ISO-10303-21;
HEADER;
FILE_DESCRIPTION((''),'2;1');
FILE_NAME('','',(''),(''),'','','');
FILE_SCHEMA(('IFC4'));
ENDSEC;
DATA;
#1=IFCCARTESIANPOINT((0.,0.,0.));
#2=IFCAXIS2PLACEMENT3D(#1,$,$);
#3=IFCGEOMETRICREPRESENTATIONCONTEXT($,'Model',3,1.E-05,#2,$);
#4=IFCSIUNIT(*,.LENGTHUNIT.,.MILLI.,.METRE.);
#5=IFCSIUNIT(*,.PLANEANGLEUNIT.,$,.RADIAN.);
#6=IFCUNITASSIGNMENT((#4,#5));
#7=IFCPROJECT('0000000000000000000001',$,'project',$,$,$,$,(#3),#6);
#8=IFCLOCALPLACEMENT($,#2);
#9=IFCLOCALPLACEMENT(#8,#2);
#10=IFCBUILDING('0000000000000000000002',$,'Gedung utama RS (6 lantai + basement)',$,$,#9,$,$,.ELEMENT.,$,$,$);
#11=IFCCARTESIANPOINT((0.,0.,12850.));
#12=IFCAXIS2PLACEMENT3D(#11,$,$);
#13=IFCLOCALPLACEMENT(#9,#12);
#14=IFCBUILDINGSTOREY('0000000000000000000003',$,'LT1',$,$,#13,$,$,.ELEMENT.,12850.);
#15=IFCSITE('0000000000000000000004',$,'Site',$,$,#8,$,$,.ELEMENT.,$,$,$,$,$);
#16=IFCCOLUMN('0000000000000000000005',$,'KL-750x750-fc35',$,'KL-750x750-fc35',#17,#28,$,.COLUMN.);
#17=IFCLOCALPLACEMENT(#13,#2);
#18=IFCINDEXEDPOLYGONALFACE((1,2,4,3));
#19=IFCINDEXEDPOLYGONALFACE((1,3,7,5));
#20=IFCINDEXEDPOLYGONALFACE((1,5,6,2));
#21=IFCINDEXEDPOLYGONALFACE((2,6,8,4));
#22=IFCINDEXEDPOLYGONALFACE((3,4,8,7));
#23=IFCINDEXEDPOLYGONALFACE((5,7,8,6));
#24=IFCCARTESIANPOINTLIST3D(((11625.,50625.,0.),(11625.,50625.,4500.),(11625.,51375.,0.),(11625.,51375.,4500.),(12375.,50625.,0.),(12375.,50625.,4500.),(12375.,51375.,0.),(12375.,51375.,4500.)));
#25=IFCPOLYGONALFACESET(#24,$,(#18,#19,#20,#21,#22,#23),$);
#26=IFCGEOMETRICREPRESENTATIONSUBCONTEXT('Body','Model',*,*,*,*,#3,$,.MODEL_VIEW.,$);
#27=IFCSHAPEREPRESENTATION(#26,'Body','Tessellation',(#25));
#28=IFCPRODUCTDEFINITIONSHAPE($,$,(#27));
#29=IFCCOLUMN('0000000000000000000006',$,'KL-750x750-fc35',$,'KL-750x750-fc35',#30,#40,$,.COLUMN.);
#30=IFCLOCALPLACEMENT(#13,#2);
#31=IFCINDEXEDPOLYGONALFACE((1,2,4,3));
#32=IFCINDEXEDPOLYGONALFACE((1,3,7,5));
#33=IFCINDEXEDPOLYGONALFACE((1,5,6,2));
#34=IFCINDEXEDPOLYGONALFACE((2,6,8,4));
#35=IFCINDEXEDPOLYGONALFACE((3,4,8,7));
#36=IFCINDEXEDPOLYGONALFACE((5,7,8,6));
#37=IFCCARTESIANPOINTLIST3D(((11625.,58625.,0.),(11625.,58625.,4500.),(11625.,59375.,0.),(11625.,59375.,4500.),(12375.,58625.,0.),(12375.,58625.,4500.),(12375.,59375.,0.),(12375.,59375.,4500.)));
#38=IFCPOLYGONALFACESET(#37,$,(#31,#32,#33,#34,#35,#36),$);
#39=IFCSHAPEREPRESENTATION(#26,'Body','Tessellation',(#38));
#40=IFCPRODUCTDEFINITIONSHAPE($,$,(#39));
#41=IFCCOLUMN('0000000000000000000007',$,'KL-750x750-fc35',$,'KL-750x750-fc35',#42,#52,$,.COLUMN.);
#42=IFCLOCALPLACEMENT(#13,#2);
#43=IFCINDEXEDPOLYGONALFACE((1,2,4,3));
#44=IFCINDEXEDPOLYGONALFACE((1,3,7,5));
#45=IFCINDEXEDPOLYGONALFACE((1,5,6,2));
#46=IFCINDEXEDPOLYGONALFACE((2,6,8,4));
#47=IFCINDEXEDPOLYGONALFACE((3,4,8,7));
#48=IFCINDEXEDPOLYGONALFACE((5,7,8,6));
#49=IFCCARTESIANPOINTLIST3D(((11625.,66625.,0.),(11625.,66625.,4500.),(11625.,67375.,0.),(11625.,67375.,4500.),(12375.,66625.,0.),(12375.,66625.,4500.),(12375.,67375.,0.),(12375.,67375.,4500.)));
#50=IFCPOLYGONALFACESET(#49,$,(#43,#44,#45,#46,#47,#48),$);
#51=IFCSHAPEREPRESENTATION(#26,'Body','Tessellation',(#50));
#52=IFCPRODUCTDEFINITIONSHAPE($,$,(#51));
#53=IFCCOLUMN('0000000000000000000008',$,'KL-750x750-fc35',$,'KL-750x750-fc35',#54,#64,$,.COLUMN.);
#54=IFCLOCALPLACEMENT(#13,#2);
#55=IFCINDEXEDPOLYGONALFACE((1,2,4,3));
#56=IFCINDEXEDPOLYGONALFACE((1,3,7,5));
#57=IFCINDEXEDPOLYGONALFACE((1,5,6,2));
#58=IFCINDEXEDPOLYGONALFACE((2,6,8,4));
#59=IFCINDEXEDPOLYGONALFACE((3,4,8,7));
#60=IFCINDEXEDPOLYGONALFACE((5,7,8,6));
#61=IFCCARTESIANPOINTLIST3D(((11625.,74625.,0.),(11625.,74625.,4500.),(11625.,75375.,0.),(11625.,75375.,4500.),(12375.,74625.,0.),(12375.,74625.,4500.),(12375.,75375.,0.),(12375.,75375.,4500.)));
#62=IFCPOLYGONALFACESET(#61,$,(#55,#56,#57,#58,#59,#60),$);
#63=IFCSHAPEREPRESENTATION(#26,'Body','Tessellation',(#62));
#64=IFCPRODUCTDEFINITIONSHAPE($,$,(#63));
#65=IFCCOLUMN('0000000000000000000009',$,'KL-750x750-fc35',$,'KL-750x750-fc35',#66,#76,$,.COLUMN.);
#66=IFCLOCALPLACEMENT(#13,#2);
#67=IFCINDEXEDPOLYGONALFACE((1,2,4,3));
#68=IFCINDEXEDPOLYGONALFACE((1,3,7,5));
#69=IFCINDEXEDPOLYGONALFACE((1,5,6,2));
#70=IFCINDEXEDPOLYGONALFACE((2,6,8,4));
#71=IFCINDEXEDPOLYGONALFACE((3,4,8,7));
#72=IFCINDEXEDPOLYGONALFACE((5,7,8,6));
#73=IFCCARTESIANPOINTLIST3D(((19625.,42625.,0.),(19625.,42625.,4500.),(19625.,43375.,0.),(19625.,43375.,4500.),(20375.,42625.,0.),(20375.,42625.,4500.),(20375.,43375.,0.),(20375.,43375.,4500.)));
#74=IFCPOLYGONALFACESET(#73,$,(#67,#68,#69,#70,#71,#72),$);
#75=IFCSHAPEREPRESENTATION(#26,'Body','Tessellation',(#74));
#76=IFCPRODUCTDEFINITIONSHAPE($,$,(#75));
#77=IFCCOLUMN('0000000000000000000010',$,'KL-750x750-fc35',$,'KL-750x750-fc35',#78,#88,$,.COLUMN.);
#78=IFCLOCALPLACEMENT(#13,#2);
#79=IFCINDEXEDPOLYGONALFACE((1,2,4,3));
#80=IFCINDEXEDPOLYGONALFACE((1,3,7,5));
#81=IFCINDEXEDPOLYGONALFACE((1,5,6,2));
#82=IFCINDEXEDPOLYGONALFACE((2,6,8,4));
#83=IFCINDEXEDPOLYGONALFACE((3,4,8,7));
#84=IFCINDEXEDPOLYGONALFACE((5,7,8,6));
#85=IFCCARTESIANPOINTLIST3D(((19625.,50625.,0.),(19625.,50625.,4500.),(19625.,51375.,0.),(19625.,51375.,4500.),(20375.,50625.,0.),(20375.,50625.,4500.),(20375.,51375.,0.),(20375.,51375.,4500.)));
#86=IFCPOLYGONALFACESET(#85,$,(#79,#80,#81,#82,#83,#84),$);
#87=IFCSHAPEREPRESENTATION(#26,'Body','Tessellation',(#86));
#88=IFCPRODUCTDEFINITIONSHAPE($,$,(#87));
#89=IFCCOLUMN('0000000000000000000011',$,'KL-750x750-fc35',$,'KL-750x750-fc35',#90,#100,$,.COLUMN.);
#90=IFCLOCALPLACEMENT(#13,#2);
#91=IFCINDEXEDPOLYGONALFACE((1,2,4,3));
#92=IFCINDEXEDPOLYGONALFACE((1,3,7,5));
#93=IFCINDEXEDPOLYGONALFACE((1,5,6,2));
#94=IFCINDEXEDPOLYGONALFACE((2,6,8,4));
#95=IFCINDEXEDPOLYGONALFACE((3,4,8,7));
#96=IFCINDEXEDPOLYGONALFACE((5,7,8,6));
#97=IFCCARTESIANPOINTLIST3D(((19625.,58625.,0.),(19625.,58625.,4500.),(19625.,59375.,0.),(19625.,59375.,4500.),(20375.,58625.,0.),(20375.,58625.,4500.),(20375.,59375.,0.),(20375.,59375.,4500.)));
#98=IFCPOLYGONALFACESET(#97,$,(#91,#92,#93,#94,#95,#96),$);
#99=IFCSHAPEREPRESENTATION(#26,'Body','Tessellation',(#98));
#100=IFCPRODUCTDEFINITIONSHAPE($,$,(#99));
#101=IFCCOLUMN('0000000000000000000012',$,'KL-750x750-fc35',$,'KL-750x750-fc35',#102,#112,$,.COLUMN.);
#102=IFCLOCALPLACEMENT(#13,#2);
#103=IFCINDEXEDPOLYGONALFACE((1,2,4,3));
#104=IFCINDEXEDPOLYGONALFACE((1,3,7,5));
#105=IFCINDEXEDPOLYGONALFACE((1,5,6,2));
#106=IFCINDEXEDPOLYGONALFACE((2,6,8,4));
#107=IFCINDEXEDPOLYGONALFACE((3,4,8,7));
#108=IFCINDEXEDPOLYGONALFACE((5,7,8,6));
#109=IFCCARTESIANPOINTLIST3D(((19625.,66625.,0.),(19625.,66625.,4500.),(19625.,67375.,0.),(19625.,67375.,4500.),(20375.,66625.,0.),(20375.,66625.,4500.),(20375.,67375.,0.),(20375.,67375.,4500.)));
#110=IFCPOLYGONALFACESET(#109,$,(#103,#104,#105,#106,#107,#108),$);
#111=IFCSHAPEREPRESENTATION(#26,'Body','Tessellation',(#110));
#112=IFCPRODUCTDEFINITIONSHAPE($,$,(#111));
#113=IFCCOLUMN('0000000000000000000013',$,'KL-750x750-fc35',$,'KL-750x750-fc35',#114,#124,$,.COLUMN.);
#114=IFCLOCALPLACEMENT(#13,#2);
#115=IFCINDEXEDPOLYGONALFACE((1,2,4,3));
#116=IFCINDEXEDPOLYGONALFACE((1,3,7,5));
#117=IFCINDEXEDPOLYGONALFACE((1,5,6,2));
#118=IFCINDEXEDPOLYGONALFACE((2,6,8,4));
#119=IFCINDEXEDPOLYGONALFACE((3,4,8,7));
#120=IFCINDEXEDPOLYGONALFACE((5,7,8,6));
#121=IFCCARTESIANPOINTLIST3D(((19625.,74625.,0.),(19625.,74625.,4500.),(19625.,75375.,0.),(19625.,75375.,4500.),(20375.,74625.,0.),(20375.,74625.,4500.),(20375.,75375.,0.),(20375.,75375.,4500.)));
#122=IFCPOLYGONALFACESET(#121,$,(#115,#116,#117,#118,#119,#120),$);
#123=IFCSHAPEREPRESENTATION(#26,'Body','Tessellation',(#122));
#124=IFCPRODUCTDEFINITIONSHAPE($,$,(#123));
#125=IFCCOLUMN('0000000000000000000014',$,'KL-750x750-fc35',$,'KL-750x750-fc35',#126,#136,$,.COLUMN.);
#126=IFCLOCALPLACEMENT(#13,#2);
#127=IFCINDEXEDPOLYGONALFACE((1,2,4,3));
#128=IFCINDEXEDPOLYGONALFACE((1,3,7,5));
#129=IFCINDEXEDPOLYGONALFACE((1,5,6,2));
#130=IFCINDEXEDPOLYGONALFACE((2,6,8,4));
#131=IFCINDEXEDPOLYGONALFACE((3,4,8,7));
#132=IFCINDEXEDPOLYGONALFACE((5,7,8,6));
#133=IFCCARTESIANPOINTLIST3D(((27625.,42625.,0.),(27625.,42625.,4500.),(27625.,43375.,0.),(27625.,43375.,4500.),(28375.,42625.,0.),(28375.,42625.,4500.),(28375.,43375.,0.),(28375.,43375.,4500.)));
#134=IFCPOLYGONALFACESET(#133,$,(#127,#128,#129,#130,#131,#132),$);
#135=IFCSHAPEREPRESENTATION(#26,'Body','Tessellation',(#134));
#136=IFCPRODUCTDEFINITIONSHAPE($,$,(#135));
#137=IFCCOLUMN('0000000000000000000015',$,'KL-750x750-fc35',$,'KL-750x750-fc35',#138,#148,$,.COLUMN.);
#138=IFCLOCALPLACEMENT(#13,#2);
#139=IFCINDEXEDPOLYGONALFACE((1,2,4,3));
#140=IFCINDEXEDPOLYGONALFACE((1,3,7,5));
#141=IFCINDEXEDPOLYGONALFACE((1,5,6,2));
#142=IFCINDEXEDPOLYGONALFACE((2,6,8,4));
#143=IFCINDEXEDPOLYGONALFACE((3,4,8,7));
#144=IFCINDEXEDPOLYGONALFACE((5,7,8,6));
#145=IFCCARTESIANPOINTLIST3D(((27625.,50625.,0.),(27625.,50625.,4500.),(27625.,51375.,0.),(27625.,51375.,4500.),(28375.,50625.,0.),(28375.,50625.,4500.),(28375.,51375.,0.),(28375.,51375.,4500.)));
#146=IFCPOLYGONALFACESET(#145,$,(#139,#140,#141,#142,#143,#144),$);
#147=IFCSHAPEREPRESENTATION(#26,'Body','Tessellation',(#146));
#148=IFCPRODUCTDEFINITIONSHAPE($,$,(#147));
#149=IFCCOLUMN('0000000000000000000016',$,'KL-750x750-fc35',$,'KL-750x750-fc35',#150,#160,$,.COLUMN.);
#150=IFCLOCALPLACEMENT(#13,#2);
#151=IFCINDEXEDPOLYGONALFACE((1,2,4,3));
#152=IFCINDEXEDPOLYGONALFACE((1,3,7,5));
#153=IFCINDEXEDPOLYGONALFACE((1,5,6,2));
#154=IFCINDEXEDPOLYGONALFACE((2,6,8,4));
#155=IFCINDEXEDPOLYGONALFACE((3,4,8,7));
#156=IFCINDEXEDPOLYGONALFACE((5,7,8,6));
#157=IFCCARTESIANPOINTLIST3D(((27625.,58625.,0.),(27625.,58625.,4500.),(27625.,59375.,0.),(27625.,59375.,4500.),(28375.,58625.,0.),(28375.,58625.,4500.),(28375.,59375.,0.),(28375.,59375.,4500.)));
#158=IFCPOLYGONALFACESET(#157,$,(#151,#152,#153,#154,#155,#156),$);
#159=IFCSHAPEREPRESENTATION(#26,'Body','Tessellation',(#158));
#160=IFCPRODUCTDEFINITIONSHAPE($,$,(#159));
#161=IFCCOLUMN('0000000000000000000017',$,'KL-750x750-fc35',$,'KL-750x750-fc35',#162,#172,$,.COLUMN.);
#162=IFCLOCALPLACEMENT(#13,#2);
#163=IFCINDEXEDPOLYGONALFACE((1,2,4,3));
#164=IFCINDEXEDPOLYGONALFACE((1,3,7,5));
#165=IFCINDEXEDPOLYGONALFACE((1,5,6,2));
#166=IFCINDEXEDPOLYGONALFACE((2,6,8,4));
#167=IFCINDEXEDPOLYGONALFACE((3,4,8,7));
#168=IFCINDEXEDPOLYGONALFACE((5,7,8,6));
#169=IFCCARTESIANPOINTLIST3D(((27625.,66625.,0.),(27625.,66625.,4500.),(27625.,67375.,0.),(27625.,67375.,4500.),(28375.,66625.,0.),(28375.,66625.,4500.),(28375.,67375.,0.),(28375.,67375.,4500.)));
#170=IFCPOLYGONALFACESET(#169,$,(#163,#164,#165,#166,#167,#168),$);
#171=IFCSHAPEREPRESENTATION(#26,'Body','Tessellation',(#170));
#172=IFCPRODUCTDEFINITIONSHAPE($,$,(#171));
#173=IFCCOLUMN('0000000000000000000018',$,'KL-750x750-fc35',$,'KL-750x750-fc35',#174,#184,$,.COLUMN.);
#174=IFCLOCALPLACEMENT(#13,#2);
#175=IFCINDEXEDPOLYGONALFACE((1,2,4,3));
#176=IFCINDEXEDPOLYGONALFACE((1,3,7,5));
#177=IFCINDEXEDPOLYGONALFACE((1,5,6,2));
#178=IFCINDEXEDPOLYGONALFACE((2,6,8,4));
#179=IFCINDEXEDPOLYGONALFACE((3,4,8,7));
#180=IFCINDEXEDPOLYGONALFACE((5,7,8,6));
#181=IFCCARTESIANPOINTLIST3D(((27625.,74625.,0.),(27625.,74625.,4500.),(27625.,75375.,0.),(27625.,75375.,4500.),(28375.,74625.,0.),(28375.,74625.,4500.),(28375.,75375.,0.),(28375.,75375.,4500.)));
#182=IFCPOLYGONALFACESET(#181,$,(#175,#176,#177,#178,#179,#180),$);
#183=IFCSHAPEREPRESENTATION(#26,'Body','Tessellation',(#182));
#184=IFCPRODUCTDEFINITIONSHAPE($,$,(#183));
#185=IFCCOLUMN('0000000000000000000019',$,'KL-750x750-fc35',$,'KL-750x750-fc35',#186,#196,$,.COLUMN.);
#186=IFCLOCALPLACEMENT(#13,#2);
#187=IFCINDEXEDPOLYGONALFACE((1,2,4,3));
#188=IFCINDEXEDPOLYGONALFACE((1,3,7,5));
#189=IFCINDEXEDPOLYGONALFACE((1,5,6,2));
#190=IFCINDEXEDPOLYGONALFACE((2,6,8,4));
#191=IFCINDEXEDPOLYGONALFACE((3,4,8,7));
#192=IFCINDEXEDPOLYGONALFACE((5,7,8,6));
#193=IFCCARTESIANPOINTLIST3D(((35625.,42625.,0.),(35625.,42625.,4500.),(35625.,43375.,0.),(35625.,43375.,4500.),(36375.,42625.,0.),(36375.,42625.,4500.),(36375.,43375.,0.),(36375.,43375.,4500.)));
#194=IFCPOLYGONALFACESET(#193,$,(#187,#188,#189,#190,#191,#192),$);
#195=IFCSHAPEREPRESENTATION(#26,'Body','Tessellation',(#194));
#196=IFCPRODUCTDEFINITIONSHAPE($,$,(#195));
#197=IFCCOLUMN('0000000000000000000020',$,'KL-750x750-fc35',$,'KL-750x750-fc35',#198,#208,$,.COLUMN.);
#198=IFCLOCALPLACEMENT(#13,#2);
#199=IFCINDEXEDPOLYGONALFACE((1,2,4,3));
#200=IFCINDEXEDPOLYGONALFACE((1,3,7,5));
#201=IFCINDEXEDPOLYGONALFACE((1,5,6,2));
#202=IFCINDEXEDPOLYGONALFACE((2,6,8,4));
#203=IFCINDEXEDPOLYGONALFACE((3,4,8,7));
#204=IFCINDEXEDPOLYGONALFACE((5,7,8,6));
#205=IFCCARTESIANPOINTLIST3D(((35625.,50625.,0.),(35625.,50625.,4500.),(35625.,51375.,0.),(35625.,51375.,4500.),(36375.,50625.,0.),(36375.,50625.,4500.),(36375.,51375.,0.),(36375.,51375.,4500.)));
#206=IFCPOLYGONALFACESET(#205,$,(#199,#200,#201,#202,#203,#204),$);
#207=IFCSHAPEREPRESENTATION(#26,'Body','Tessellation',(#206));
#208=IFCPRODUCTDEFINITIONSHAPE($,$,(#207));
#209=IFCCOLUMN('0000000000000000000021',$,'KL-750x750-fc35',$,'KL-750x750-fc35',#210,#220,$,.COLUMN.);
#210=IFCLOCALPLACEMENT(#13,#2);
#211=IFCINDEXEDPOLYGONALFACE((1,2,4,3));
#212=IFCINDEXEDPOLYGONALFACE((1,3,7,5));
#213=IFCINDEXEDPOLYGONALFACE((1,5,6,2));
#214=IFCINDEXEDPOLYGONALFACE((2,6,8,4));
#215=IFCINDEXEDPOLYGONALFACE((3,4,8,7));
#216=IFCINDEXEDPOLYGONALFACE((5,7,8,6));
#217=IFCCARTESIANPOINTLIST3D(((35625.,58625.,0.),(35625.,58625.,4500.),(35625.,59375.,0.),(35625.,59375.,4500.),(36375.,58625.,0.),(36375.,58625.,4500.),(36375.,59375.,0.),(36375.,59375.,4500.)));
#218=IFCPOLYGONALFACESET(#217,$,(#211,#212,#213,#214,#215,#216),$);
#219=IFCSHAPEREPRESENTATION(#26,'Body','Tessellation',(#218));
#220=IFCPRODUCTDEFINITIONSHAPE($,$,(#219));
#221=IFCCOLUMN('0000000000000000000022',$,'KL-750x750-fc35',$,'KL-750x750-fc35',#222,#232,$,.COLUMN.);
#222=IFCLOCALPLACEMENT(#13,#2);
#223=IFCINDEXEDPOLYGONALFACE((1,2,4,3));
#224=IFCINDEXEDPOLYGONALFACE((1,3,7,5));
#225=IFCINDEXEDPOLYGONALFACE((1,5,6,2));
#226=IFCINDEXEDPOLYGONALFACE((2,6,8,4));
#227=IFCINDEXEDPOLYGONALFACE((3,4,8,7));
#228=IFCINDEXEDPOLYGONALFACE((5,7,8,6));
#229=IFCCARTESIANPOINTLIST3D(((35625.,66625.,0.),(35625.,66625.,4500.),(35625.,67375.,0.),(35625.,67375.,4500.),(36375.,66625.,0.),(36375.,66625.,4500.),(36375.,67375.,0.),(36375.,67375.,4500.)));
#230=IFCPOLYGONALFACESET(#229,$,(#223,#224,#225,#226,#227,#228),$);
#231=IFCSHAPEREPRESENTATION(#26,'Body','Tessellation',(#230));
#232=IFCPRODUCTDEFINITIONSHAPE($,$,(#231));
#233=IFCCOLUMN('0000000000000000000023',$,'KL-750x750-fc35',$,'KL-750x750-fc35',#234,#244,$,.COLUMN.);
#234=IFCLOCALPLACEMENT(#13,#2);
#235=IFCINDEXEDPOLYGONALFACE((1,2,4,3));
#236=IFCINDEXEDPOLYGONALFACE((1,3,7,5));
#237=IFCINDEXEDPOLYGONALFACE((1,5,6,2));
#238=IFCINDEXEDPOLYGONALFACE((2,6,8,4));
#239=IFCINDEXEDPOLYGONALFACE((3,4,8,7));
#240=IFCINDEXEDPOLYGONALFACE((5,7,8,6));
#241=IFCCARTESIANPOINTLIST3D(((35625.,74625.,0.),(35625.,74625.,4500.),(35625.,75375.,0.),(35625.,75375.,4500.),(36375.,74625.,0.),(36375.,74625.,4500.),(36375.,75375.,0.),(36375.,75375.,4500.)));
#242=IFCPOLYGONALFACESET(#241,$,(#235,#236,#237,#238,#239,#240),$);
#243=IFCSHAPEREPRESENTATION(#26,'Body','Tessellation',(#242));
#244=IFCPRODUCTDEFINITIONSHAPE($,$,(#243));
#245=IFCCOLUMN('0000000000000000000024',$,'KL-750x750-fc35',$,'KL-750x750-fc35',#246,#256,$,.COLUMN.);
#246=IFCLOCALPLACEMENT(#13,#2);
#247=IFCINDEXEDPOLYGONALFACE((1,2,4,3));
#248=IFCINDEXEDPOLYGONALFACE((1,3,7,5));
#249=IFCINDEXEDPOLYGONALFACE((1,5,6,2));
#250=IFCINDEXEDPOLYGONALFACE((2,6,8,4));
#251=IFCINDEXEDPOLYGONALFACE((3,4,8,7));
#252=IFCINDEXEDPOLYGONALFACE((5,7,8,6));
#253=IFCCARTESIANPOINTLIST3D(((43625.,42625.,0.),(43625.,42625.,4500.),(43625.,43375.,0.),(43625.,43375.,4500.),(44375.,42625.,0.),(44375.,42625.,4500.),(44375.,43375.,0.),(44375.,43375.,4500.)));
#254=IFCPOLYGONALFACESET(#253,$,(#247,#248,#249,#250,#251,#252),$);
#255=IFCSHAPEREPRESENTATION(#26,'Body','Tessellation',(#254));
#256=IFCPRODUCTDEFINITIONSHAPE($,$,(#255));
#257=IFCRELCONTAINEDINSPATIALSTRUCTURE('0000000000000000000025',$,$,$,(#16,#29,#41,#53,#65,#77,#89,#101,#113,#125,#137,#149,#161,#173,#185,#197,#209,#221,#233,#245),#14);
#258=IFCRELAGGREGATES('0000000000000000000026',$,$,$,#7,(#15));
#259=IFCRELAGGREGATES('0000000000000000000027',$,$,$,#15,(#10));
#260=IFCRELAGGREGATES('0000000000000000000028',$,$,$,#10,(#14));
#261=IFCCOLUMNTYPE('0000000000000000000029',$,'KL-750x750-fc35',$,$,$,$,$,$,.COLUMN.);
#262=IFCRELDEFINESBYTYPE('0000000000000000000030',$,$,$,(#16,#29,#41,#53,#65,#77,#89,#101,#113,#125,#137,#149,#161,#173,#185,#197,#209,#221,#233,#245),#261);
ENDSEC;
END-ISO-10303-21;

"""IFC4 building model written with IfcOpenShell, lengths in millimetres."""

from ifc_helpers import new_model, si_unit, frame, origin, origin_2d, place, context, subcontext, project, spatial, rectangle, extrude, material_profile, profile_set, profile_usage, type_object, element, save


model = new_model("IFC4")

# Units and contexts
model_context = context("Model", 3, precision=1e-05, world=origin())
body_context = subcontext(model_context, "Body", "Model", "MODEL_VIEW")
ifc_project = project(units=[si_unit("LENGTHUNIT", "METRE", prefix="MILLI"), si_unit("PLANEANGLEUNIT", "RADIAN")], contexts=[model_context])

# Site, building, storey
site_placement = place(None, origin())
site = spatial("IfcSite", under=ifc_project, at=site_placement, Name="Site", CompositionType="ELEMENT")
building_placement = place(site_placement, origin())
building = spatial("IfcBuilding", under=site, at=building_placement, Name="Gedung utama RS (6 lantai + basement)", CompositionType="ELEMENT")
storey_placement = place(building_placement, frame((0.0, 0.0, 12850.0)))
storey = spatial("IfcBuildingStorey", under=building, at=storey_placement, Name="LT1", CompositionType="ELEMENT", Elevation=12850.0)

# Columns
ifc_material_profile = material_profile(None, rectangle(XDim=750.0, YDim=750.0, at=origin_2d()), Name="KL-750x750-fc35")
ifc_profile_set = profile_set([ifc_material_profile], Name="KL-750x750-fc35")
ifc_profile_usage = profile_usage(ifc_profile_set, cardinal=5)
column_type = type_object("IfcColumnType", Name="KL-750x750-fc35", PredefinedType="COLUMN", material=ifc_profile_set)
for number, where, z_axis, x_axis, name in (
    (1, (12000.0, 51000.0, 0.0), (0.0, 0.0, 1.0), (1.0, 0.0, 0.0), "KL-750x750-fc35"),
    (2, (12000.0, 59000.0, 0.0), (0.0, 0.0, 1.0), (1.0, 0.0, 0.0), "KL-750x750-fc35"),
    (3, (12000.0, 67000.0, 0.0), (0.0, 0.0, 1.0), (1.0, 0.0, 0.0), "KL-750x750-fc35"),
    (4, (12000.0, 75000.0, 0.0), (0.0, 0.0, 1.0), (1.0, 0.0, 0.0), "KL-750x750-fc35"),
    (5, (20000.0, 43000.0, 0.0), (0.0, 0.0, 1.0), (1.0, 0.0, 0.0), "KL-750x750-fc35"),
    (6, (20000.0, 51000.0, 0.0), (0.0, 0.0, 1.0), (1.0, 0.0, 0.0), "KL-750x750-fc35"),
    (7, (20000.0, 59000.0, 0.0), (0.0, 0.0, 1.0), (1.0, 0.0, 0.0), "KL-750x750-fc35"),
    (8, (20000.0, 67000.0, 0.0), (0.0, 0.0, 1.0), (1.0, 0.0, 0.0), "KL-750x750-fc35"),
    (9, (20000.0, 75000.0, 0.0), (0.0, 0.0, 1.0), (1.0, 0.0, 0.0), "KL-750x750-fc35"),
    (10, (28000.0, 43000.0, 0.0), (0.0, 0.0, 1.0), (1.0, 0.0, 0.0), "KL-750x750-fc35"),
    (11, (28000.0, 51000.0, 0.0), (0.0, 0.0, 1.0), (1.0, 0.0, 0.0), "KL-750x750-fc35"),
    (12, (28000.0, 59000.0, 0.0), (0.0, 0.0, 1.0), (1.0, 0.0, 0.0), "KL-750x750-fc35"),
    (13, (28000.0, 67000.0, 0.0), (0.0, 0.0, 1.0), (1.0, 0.0, 0.0), "KL-750x750-fc35"),
    (14, (28000.0, 75000.0, 0.0), (0.0, 0.0, 1.0), (1.0, 0.0, 0.0), "KL-750x750-fc35"),
    (15, (36000.0, 43000.0, 0.0), (0.0, 0.0, 1.0), (1.0, 0.0, 0.0), "KL-750x750-fc35"),
    (16, (36000.0, 51000.0, 0.0), (0.0, 0.0, 1.0), (1.0, 0.0, 0.0), "KL-750x750-fc35"),
    (17, (36000.0, 59000.0, 0.0), (0.0, 0.0, 1.0), (1.0, 0.0, 0.0), "KL-750x750-fc35"),
    (18, (36000.0, 67000.0, 0.0), (0.0, 0.0, 1.0), (1.0, 0.0, 0.0), "KL-750x750-fc35"),
    (19, (36000.0, 75000.0, 0.0), (0.0, 0.0, 1.0), (1.0, 0.0, 0.0), "KL-750x750-fc35"),
    (20, (44000.0, 43000.0, 0.0), (0.0, 0.0, 1.0), (1.0, 0.0, 0.0), "KL-750x750-fc35"),
):
    element("IfcColumn", number, at=place(storey_placement, frame(where, z_axis=z_axis, x_axis=x_axis)), inside=storey, type_object=column_type, material=ifc_profile_usage, Name=name, ObjectType="KL-750x750-fc35", PredefinedType="COLUMN", context=body_context, shape_type="SweptSolid", body=[
        extrude(rectangle(XDim=750.0, YDim=750.0, at=origin_2d()), origin(), (0.0, 0.0, 1.0), 4500.0),
    ])

save(model, "model.ifc")
